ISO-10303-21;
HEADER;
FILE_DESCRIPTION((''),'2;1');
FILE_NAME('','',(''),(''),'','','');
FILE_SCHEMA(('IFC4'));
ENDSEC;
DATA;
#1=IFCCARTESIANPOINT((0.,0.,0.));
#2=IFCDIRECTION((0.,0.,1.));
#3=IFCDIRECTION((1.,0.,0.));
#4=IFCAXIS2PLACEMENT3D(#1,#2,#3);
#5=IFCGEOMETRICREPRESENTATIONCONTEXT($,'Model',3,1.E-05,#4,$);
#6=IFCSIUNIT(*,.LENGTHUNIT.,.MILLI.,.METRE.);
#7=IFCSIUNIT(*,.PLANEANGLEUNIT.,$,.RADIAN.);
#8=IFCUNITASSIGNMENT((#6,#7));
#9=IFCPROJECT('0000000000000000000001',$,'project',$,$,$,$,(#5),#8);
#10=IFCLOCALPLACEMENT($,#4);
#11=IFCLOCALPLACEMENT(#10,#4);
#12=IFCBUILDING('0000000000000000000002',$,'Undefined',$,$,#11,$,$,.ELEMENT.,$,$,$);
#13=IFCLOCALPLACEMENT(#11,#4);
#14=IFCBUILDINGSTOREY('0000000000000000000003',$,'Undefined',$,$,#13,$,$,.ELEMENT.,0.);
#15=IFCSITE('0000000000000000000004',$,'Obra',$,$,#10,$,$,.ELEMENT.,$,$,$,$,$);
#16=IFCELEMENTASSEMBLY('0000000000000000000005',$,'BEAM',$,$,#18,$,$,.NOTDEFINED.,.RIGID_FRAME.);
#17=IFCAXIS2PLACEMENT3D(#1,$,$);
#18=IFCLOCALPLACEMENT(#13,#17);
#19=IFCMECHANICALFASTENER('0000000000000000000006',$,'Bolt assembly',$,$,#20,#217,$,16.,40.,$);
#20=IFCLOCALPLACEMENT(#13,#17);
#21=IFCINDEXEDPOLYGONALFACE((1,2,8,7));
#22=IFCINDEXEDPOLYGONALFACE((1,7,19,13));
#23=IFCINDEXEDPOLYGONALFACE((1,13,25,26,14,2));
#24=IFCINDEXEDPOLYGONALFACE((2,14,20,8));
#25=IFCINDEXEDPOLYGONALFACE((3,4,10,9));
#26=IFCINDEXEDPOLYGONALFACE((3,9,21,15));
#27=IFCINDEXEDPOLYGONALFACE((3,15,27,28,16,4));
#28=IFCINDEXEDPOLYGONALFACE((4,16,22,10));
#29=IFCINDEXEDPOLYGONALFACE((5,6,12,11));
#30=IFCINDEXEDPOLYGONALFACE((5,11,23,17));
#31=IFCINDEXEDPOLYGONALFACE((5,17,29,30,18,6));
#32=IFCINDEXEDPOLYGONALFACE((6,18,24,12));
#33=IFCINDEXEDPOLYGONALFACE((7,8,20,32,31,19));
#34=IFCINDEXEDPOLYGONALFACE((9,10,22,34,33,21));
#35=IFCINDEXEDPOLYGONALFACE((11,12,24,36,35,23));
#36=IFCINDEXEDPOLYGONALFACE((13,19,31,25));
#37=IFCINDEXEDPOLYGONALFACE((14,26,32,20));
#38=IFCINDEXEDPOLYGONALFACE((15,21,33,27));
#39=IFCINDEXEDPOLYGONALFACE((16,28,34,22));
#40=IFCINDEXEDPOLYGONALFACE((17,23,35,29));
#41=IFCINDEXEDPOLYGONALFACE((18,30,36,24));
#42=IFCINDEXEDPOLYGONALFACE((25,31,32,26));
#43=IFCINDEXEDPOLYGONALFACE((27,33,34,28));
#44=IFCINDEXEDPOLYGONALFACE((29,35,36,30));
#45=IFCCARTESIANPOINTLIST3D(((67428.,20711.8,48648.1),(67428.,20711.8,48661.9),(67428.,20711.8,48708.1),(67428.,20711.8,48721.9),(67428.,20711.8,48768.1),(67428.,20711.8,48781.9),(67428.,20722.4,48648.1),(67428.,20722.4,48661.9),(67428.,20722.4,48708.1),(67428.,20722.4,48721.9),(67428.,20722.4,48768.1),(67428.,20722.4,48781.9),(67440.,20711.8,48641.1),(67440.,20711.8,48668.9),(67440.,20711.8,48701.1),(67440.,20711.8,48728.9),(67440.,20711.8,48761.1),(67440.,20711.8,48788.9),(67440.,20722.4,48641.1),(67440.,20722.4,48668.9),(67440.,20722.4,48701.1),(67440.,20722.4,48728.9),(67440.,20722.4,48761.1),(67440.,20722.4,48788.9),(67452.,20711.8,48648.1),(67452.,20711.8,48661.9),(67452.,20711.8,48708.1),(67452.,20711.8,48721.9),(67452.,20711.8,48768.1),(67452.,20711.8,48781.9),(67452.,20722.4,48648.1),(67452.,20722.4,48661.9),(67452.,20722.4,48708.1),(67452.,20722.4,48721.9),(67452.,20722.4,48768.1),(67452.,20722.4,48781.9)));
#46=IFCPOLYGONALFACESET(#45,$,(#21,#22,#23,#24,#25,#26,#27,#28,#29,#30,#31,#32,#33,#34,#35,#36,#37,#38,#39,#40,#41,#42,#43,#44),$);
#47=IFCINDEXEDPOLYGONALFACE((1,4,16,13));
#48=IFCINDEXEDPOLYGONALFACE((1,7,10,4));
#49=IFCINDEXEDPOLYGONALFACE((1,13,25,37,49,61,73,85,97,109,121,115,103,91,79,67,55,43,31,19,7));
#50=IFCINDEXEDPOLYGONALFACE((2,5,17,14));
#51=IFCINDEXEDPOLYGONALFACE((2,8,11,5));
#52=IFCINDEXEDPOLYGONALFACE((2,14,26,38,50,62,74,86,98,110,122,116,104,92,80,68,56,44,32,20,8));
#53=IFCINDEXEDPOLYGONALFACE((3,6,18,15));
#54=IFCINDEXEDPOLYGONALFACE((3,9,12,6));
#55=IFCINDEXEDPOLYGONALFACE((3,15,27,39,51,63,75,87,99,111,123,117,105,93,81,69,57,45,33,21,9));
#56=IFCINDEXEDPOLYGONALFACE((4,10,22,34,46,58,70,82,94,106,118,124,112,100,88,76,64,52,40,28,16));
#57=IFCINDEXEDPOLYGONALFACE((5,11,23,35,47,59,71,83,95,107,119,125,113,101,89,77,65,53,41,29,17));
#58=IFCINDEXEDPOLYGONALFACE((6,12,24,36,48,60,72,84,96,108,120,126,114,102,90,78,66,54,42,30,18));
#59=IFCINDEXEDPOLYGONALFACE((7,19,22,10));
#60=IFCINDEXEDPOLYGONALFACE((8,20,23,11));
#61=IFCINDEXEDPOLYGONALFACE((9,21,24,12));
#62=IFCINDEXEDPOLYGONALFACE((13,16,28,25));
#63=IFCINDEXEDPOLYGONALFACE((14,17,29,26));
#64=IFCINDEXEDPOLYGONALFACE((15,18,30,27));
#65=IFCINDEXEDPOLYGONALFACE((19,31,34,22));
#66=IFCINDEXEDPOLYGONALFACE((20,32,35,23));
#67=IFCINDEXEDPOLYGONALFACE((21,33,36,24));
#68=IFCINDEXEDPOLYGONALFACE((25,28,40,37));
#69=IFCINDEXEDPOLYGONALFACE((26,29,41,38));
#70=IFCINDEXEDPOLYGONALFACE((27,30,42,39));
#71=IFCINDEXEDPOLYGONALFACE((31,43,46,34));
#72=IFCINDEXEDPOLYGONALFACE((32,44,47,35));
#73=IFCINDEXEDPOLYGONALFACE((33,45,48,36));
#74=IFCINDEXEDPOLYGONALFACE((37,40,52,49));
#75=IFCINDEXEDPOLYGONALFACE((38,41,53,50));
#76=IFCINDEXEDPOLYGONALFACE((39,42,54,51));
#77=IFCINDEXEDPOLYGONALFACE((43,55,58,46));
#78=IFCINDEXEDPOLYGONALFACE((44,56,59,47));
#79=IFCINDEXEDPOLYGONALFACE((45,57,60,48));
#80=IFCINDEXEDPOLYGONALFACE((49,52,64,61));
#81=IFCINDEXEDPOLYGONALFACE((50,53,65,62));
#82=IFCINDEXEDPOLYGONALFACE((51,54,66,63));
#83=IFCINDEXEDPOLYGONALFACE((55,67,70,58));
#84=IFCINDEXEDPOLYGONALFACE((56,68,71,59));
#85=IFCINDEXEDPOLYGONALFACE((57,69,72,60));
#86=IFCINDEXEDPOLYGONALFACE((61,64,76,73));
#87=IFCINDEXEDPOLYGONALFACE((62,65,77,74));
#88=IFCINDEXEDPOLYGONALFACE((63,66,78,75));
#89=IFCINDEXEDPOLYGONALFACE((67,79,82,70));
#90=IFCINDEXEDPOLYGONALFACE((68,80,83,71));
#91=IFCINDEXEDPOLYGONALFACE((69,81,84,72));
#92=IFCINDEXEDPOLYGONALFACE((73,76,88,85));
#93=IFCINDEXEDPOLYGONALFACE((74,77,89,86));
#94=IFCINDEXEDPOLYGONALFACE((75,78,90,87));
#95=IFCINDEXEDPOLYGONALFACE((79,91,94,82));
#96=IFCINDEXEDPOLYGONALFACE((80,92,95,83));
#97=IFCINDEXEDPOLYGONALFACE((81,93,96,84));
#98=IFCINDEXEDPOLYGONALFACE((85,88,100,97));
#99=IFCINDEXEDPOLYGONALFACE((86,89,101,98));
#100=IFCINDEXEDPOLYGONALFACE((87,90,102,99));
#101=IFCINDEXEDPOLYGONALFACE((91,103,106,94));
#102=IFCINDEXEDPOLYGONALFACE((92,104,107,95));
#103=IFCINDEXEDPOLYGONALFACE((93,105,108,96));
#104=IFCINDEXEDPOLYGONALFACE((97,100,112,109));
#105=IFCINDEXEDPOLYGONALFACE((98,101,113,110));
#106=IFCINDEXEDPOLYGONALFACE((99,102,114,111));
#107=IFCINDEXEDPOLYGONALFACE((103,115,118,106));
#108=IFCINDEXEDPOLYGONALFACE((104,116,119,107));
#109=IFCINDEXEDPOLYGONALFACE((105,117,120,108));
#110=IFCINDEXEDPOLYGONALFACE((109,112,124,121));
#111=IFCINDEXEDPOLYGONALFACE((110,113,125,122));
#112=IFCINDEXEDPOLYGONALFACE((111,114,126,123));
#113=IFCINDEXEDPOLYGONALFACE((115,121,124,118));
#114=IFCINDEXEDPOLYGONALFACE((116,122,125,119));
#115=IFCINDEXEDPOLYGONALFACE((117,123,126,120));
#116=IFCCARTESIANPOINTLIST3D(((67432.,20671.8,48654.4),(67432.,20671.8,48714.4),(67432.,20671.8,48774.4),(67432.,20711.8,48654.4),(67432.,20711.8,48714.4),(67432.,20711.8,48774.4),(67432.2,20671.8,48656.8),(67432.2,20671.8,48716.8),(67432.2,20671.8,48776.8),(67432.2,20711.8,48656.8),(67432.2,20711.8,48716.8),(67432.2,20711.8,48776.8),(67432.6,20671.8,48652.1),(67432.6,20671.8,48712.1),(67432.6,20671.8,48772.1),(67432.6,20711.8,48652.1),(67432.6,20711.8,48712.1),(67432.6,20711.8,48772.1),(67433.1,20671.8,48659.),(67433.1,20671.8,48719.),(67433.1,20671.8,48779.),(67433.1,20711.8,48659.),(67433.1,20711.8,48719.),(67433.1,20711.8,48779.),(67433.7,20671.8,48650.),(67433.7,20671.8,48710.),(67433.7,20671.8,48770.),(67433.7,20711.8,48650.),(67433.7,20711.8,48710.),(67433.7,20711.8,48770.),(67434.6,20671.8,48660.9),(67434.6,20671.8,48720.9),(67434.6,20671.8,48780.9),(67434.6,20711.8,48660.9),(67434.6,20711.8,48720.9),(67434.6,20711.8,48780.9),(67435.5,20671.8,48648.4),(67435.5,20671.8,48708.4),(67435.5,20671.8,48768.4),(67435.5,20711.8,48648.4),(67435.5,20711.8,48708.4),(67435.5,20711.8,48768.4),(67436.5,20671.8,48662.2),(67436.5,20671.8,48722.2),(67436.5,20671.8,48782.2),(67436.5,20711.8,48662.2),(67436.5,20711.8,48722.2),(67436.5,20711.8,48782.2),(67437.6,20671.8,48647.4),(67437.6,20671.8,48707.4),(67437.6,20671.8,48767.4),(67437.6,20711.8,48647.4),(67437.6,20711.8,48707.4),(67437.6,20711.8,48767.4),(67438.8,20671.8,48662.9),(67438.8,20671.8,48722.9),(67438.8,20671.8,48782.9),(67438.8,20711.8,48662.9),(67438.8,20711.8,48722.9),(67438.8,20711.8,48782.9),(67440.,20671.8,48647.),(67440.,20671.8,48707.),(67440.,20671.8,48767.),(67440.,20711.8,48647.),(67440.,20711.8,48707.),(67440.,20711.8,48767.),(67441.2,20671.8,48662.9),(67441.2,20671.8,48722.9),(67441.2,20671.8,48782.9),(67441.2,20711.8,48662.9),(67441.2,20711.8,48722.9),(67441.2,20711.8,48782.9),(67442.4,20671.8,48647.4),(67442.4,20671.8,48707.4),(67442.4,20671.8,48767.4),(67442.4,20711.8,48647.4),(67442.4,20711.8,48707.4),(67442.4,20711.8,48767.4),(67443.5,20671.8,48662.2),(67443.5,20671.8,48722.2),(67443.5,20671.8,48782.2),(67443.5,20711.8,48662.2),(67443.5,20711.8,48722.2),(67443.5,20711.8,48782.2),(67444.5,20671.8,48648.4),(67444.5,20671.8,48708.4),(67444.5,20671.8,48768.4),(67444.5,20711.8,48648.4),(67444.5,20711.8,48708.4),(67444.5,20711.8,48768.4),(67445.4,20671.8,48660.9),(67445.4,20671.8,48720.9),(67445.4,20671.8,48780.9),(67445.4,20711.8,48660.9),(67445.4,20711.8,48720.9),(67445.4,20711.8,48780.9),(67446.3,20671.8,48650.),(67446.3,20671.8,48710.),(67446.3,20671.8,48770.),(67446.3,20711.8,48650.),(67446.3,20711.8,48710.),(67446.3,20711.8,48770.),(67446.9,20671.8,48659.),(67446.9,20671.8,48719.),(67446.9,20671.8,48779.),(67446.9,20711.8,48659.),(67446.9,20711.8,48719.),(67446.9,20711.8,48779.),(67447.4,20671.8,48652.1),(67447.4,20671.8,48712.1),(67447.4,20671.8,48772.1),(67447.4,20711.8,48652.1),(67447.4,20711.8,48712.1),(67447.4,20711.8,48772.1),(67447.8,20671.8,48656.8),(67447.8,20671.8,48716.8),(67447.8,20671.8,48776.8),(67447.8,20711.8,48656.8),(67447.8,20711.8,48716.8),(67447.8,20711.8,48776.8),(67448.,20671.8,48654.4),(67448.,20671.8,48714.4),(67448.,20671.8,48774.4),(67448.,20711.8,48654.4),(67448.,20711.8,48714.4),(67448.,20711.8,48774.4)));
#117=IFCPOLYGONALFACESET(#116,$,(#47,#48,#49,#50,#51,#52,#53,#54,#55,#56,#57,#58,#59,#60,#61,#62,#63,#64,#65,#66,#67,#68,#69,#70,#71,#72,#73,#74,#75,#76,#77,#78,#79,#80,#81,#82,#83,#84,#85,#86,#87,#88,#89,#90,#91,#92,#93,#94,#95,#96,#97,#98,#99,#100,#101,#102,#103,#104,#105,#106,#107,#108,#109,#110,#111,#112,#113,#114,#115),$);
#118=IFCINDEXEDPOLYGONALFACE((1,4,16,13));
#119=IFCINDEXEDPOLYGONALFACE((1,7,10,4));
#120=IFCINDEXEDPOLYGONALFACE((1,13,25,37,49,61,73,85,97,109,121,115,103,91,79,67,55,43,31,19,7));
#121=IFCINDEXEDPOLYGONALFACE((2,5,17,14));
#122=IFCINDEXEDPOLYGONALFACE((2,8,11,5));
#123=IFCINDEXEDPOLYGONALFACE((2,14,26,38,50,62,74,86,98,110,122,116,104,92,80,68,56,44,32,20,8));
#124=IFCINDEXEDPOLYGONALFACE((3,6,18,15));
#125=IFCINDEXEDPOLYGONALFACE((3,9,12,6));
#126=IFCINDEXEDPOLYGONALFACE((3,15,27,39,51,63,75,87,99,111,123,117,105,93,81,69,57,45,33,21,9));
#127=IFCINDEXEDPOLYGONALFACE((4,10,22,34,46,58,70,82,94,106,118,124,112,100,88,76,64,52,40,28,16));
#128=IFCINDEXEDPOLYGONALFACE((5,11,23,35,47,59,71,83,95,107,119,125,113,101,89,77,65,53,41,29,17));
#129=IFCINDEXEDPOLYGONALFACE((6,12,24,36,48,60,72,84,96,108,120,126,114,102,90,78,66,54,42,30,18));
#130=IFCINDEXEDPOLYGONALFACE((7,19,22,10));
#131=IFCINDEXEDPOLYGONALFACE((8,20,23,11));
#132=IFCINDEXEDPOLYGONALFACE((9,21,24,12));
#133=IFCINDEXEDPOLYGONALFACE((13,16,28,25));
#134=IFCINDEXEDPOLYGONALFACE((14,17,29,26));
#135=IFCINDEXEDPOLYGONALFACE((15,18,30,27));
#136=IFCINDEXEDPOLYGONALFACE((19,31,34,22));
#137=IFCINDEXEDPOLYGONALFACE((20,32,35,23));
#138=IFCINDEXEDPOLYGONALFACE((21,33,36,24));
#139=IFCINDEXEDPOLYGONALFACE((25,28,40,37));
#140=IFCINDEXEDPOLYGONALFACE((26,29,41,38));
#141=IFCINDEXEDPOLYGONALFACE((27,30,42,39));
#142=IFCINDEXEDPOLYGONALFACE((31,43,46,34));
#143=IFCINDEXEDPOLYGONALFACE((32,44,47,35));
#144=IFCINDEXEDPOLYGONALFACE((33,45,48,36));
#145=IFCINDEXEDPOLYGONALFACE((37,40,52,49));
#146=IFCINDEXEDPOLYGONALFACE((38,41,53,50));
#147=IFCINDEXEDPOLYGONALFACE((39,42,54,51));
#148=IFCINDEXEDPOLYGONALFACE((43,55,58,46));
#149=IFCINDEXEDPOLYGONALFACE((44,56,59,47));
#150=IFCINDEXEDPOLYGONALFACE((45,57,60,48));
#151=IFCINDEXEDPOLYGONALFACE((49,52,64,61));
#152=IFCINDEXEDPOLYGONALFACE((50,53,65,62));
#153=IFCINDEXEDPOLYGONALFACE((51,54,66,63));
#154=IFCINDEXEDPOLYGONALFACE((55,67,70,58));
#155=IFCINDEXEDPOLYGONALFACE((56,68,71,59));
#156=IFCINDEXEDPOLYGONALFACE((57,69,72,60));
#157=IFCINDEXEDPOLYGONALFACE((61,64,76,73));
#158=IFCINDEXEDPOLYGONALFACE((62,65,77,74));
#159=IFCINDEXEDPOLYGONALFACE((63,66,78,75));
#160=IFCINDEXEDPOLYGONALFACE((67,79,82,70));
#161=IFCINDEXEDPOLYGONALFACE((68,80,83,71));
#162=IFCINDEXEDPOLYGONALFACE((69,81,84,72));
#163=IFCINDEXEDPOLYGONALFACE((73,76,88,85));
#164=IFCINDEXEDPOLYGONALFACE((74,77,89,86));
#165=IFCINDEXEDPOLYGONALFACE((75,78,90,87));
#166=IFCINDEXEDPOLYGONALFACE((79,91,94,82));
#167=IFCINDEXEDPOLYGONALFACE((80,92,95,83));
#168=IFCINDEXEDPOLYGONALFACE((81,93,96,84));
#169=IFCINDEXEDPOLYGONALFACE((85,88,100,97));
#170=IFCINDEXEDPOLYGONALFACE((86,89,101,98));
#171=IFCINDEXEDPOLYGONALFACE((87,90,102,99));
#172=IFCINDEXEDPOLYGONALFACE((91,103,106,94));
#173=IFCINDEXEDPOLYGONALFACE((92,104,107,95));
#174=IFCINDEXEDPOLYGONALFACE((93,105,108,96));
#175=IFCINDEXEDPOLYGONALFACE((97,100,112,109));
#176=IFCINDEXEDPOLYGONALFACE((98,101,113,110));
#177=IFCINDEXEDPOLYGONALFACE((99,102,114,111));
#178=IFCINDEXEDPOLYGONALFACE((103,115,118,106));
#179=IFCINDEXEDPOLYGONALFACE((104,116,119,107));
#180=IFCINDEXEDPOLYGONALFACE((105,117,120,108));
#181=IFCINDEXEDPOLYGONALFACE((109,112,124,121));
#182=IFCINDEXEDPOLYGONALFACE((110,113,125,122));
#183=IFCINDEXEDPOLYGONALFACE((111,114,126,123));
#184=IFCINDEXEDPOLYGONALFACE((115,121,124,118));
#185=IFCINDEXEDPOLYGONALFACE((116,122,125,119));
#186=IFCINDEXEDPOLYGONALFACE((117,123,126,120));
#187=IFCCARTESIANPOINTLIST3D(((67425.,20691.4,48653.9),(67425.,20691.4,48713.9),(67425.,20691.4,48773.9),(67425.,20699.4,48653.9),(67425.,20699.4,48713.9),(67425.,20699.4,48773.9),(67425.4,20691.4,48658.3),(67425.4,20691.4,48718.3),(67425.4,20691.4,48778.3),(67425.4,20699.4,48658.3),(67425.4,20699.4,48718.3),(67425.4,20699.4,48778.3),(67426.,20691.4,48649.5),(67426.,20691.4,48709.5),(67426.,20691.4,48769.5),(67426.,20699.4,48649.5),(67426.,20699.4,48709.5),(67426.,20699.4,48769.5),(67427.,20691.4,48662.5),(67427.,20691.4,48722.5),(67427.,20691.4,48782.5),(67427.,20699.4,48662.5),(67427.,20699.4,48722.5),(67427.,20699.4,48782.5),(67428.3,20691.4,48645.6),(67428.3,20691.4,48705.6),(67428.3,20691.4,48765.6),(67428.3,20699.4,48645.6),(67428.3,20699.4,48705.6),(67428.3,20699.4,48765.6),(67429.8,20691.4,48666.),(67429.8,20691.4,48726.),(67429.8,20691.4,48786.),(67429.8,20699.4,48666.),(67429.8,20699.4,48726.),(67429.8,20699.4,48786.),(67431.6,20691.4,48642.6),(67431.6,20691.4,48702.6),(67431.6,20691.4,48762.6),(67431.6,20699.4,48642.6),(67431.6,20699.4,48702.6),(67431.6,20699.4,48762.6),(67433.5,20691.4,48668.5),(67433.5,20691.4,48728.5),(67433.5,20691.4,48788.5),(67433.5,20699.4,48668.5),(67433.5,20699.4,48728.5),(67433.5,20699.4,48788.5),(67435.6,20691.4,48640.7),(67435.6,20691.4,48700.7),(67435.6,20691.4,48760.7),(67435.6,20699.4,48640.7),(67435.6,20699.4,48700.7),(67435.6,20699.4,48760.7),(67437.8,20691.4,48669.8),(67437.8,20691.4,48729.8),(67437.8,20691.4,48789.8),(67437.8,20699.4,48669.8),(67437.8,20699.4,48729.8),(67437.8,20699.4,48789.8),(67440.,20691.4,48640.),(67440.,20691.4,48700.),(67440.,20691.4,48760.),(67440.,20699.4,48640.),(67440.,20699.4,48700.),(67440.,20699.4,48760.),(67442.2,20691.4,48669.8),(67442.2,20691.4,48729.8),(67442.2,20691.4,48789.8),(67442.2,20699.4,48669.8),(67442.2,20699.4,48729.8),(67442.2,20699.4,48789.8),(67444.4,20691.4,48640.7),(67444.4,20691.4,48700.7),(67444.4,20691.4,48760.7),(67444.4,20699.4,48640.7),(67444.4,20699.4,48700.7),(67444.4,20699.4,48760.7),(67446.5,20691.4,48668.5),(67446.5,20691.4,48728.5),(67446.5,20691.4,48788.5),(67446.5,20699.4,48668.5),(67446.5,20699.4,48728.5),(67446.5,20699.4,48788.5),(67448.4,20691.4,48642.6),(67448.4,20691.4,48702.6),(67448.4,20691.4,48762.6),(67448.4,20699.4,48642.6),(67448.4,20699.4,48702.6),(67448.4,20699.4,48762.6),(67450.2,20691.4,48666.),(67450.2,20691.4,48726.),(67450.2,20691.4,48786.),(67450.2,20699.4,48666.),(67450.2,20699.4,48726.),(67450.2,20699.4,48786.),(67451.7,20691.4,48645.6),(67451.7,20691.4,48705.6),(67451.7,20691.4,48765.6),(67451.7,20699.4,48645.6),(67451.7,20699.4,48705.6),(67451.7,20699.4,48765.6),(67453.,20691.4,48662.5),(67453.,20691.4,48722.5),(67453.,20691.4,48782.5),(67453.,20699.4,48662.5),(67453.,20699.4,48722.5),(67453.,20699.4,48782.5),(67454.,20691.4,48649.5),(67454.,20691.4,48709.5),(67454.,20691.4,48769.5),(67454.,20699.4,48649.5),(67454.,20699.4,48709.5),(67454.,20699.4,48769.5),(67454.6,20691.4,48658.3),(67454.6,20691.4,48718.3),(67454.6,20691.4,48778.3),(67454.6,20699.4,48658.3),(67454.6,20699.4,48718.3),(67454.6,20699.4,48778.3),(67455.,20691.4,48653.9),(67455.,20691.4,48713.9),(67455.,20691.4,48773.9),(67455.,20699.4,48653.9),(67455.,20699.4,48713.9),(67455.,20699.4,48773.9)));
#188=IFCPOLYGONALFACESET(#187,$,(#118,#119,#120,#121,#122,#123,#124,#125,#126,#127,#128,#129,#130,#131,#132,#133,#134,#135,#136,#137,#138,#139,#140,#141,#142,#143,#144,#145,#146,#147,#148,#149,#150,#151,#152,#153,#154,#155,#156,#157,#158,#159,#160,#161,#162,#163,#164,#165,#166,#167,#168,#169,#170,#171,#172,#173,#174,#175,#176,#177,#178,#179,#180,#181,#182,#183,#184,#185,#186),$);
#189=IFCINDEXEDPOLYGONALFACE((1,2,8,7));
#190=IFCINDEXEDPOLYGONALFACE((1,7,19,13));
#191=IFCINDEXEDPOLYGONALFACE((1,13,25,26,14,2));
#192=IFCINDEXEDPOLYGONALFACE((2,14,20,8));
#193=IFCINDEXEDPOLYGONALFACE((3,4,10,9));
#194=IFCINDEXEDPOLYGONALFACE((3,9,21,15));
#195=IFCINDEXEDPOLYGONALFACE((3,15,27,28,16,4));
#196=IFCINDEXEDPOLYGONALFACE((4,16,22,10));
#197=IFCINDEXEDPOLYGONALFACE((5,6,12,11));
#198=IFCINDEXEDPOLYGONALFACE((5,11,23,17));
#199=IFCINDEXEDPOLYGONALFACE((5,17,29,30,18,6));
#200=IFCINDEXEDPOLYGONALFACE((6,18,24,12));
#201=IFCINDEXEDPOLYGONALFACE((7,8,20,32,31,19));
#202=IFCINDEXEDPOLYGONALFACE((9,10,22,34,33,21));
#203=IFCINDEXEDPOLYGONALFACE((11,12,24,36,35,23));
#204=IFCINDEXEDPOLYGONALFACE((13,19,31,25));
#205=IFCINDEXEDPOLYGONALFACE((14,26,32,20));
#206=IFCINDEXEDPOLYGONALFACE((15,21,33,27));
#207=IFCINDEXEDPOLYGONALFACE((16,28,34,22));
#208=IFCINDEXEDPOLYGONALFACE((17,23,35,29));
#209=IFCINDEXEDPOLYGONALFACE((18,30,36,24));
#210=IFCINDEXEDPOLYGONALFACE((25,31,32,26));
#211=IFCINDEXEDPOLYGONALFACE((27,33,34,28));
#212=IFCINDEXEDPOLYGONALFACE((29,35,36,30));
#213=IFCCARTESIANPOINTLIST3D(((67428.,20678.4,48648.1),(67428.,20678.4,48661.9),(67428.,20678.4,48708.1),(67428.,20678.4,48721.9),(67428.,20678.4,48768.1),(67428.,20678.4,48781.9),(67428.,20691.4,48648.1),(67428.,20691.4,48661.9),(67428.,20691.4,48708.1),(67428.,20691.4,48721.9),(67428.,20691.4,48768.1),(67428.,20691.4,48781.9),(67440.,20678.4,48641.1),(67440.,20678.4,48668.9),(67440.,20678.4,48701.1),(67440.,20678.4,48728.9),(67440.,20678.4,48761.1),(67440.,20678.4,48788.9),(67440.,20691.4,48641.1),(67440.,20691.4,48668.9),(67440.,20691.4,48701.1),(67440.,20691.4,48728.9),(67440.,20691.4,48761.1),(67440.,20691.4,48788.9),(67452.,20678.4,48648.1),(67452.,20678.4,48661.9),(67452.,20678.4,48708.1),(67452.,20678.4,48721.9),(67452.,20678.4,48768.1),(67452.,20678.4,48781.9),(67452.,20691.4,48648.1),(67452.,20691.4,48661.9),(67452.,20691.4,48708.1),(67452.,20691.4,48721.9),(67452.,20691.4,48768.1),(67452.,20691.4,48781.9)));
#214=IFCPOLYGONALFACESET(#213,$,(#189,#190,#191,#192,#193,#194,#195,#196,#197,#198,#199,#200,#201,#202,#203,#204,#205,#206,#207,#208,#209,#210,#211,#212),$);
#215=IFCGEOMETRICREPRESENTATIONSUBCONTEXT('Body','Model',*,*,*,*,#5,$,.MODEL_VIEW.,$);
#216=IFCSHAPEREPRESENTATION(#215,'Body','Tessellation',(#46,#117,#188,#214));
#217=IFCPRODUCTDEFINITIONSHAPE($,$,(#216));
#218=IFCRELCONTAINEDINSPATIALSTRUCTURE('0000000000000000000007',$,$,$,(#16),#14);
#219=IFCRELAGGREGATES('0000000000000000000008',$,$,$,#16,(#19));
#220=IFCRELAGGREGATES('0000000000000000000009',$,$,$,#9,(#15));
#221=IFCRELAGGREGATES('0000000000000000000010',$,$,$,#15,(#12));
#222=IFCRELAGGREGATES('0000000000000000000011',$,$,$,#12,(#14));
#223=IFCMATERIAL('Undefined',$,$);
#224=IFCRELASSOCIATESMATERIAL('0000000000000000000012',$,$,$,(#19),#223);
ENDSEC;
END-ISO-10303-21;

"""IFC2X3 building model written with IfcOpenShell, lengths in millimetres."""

from ifc_helpers import new_model, si_unit, frame, origin_with_axes, origin_2d_with_axis, place, context, subcontext, project, spatial, polyline, circle, outline, extrude, source, transform, mapped, material, element, aggregate, save


model = new_model("IFC2X3")

# Units and contexts
model_context = context("Model", 3, precision=1e-05, world=origin_with_axes())
body_context = subcontext(model_context, "Body", "Model", "MODEL_VIEW")
ifc_project = project(units=[si_unit("LENGTHUNIT", "METRE", prefix="MILLI"), si_unit("PLANEANGLEUNIT", "RADIAN")], contexts=[model_context])

# Site, building, storey
site_placement = place(None, origin_with_axes())
site = spatial("IfcSite", under=ifc_project, at=site_placement, Name="Obra", CompositionType="ELEMENT")
building_placement = place(site_placement, origin_with_axes())
building = spatial("IfcBuilding", under=site, at=building_placement, Name="Undefined", CompositionType="ELEMENT")
storey_placement = place(building_placement, origin_with_axes())
storey = spatial("IfcBuildingStorey", under=building, at=storey_placement, Name="Undefined", CompositionType="ELEMENT", Elevation=0.0)

# Element assembly, mechanical fastener
ifc_material_1 = material(Name="Undefined")
assembly_1_placement = place(storey_placement, origin_with_axes())
assembly_1 = element("IfcElementAssembly", 1, at=assembly_1_placement, inside=storey, Name="BEAM", AssemblyPlace="NOTDEFINED", PredefinedType="RIGID_FRAME")
shared_shape_1 = source(origin_with_axes(), body_context, "Body", "SweptSolid", [
    extrude(outline(polyline([(13.9, 0.0), (6.9, 12.0), (-6.9, 12.0), (-13.9, 0.0), (-6.9, -12.0), (6.9, -12.0), (13.9, 0.0)])), frame((0.0, -19.7, 0.0), z_axis=(0.0, 1.0, 0.0), x_axis=(1.0, 0.0, 0.0)), (0.0, 0.0, 1.0), 10.6),
    extrude(circle(Radius=8.0, at=origin_2d_with_axis()), frame((0.0, -9.1, 0.0), z_axis=(0.0, 1.0, 0.0), x_axis=(1.0, 0.0, 0.0)), (0.0, 0.0, 1.0), 40.0),
    extrude(circle(Radius=15.0, at=origin_2d_with_axis()), frame((0.0, 3.3, 0.0), z_axis=(0.0, 1.0, 0.0), x_axis=(1.0, 0.0, 0.0)), (0.0, 0.0, 1.0), 8.0),
    extrude(outline(polyline([(13.9, 0.0), (6.9, 12.0), (-6.9, 12.0), (-13.9, 0.0), (-6.9, -12.0), (6.9, -12.0), (13.9, 0.0)])), frame((0.0, 11.3, 0.0), z_axis=(0.0, 1.0, 0.0), x_axis=(1.0, 0.0, 0.0)), (0.0, 0.0, 1.0), 13.0),
])
mechanical_fastener_1_placement = place(assembly_1_placement, frame((67490.0, 20702.7, 48835.0), z_axis=(-1.0, 0.0, 0.0), x_axis=(0.0, 0.0, -1.0)))
mechanical_fastener_1 = element("IfcMechanicalFastener", 2, at=mechanical_fastener_1_placement, material=ifc_material_1, Name="Bolt assembly", NominalDiameter=16.0, NominalLength=40.0, context=body_context, shape_type="MappedRepresentation", body=[
    mapped(shared_shape_1, transform((60.0, 0.0, 50.0))),
    mapped(shared_shape_1, transform((120.0, 0.0, 50.0))),
    mapped(shared_shape_1, transform((180.0, 0.0, 50.0))),
])
aggregate(assembly_1, [mechanical_fastener_1])

save(model, "model.ifc")
